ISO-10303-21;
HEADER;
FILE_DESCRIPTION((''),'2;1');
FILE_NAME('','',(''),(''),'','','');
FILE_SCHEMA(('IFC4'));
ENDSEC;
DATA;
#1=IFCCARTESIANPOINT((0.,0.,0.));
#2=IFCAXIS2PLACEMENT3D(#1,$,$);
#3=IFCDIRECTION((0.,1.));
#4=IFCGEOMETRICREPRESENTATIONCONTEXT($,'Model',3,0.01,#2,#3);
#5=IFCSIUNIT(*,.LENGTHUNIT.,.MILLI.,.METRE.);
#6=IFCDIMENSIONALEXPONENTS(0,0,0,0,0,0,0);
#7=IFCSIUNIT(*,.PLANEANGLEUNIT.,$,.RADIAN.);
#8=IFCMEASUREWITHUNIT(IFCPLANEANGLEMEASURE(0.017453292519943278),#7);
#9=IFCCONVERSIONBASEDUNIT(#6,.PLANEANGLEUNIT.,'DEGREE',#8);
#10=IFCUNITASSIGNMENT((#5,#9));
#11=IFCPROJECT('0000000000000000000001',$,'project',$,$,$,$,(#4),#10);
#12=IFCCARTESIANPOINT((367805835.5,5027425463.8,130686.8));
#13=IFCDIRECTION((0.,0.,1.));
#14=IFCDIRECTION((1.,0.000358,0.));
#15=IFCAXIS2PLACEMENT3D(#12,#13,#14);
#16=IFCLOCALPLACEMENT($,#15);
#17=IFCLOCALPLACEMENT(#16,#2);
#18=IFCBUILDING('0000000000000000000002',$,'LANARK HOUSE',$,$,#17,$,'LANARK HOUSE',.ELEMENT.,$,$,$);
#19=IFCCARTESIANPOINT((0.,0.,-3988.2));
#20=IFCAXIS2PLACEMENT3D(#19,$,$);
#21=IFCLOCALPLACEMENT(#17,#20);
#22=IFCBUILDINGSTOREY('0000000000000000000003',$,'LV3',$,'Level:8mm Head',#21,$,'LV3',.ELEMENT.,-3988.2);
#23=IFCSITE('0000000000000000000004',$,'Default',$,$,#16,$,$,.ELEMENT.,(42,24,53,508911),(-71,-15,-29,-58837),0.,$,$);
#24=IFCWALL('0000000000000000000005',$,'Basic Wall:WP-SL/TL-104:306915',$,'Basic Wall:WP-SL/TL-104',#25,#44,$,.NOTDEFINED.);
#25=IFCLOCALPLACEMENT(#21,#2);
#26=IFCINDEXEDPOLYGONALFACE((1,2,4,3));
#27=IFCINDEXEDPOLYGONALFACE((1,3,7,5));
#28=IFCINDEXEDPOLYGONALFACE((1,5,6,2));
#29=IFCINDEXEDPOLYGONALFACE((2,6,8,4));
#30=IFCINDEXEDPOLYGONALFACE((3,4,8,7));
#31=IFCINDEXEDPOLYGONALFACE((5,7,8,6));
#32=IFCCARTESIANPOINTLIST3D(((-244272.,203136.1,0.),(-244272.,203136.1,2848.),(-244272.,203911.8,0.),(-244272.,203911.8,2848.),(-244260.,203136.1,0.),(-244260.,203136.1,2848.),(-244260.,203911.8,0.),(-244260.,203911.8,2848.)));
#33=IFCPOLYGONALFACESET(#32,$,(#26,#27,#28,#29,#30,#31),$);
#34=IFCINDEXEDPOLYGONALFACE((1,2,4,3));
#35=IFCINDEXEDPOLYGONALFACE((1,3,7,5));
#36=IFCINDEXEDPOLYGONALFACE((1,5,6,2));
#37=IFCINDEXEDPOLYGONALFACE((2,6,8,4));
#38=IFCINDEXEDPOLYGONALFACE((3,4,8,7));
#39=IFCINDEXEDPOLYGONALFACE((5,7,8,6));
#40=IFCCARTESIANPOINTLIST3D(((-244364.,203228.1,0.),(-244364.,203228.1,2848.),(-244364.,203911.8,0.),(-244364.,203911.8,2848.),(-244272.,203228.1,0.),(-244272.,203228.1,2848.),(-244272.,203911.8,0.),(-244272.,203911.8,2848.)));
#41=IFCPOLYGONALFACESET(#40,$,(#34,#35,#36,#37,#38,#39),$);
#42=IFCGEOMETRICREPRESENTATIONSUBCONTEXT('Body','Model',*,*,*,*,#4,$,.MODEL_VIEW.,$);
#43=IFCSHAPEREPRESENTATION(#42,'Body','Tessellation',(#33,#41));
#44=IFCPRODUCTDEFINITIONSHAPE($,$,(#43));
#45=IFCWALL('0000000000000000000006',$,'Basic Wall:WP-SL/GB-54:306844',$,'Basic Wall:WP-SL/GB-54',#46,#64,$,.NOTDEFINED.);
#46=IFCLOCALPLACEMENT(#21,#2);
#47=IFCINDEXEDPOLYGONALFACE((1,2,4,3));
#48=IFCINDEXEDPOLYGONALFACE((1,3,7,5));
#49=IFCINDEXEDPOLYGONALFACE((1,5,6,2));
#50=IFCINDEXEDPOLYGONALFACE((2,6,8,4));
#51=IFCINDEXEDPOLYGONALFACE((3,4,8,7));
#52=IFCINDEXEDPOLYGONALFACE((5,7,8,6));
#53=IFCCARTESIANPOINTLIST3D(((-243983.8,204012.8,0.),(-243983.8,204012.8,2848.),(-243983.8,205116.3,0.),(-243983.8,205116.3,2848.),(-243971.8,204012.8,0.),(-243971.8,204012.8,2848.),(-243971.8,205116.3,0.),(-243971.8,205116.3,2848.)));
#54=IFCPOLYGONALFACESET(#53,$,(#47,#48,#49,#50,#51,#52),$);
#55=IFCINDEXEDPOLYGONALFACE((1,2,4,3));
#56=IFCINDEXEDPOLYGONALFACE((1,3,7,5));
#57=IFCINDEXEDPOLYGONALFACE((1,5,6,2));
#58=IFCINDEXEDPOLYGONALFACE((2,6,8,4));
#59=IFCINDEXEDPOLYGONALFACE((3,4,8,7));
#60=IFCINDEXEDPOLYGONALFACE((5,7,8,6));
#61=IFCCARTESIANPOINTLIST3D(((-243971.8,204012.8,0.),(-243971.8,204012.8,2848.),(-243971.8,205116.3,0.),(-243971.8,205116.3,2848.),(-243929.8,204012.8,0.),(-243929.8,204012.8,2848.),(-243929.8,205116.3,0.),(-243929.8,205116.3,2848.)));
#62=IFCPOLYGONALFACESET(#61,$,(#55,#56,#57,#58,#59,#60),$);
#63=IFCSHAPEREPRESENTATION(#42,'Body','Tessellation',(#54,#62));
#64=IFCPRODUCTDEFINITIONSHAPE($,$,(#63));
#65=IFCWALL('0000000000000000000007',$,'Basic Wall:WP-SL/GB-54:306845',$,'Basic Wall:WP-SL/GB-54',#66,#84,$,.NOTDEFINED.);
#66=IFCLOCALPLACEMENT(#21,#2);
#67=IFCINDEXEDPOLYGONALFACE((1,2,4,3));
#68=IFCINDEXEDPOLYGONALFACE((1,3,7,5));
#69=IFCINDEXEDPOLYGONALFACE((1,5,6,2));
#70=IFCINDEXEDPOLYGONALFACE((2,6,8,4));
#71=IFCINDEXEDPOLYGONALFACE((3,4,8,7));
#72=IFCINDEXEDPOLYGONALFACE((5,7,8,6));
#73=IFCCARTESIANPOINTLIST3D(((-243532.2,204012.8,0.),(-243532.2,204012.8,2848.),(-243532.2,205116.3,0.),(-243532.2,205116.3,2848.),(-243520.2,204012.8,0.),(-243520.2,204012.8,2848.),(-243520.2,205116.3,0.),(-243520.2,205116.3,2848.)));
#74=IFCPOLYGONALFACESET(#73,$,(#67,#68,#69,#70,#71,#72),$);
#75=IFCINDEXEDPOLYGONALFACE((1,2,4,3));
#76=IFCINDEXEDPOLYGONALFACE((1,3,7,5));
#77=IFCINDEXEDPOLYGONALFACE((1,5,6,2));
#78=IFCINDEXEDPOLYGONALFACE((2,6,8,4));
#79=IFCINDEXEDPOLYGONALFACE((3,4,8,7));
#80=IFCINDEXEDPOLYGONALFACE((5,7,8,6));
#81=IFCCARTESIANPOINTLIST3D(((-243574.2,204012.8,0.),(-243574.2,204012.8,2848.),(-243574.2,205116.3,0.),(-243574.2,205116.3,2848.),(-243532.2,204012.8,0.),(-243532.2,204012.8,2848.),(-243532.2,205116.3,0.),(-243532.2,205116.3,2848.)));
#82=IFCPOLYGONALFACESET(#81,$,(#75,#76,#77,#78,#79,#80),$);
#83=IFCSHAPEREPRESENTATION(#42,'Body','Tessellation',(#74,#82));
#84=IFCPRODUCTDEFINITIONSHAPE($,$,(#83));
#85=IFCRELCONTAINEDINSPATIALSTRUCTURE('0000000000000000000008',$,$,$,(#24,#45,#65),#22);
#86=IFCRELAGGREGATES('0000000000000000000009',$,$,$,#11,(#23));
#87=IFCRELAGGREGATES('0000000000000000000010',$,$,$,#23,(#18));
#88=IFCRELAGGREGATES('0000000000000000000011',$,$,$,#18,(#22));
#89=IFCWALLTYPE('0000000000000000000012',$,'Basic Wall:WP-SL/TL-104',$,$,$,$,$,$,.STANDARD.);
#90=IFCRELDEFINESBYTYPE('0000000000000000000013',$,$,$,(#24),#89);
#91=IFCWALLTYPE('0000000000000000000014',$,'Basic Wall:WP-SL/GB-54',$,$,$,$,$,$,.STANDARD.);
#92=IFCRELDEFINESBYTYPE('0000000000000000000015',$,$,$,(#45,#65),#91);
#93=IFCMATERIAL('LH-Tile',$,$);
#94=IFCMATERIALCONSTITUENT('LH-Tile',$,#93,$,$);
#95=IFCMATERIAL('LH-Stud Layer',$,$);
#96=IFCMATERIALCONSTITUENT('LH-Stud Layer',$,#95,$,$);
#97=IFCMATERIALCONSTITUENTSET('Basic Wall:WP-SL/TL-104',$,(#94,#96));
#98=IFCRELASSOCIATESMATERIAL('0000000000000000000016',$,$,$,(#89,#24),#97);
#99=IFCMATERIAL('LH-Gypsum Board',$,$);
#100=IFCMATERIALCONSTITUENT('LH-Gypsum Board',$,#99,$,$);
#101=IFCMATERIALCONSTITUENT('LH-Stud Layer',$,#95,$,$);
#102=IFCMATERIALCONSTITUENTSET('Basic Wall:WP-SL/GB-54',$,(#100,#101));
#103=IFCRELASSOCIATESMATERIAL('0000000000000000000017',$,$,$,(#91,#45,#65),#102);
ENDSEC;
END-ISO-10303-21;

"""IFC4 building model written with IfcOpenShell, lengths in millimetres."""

from ifc_helpers import new_model, entity, si_unit, converted_unit, direction, frame, origin, place, context, subcontext, project, spatial, indexed_curve, outline, extrude, material, constituent, constituent_set, type_object, element, save


model = new_model("IFC4")

# Units and contexts
model_context = context("Model", 3, precision=0.01, world=origin(), true_north=direction((0.0, 1.0)))
body_context = subcontext(model_context, "Body", "Model", "MODEL_VIEW")
ifc_project = project(units=[si_unit("LENGTHUNIT", "METRE", prefix="MILLI"), converted_unit("PLANEANGLEUNIT", "DEGREE", entity("IfcPlaneAngleMeasure", 0.017453292519943278), si_unit("PLANEANGLEUNIT", "RADIAN"), dimensions=[0, 0, 0, 0, 0, 0, 0])], contexts=[model_context])

# Site, building, storey
site_placement = place(None, frame((367805835.5, 5027425463.8, 130686.8), z_axis=(0.0, 0.0, 1.0), x_axis=(1.0, 0.000358, 0.0)))
site = spatial("IfcSite", under=ifc_project, at=site_placement, Name="Default", CompositionType="ELEMENT", RefLatitude=(42, 24, 53, 508911), RefLongitude=(-71, -15, -29, -58837), RefElevation=0.0)
building_placement = place(site_placement, origin())
building = spatial("IfcBuilding", under=site, at=building_placement, Name="LANARK HOUSE", LongName="LANARK HOUSE", CompositionType="ELEMENT")
storey_placement = place(building_placement, frame((0.0, 0.0, -3988.2)))
storey = spatial("IfcBuildingStorey", under=building, at=storey_placement, Name="LV3", ObjectType="Level:8mm Head", LongName="LV3", CompositionType="ELEMENT", Elevation=-3988.2)

# Walls
ifc_material_1 = material(Name="LH-Tile")
ifc_constituent_1 = constituent(ifc_material_1, Name="LH-Tile")
ifc_material_2 = material(Name="LH-Stud Layer")
ifc_constituent_2 = constituent(ifc_material_2, Name="LH-Stud Layer")
ifc_constituent_set_1 = constituent_set(constituents=[ifc_constituent_1, ifc_constituent_2], Name="Basic Wall:WP-SL/TL-104")
wall_type_1 = type_object("IfcWallType", Name="Basic Wall:WP-SL/TL-104", PredefinedType="STANDARD", material=ifc_constituent_set_1)
wall_1_placement = place(storey_placement, frame((-244312.0, 203911.8, 0.0), z_axis=(0.0, 0.0, 1.0), x_axis=(0.0, -1.0, 0.0)))
element("IfcWall", 1, at=wall_1_placement, inside=storey, type_object=wall_type_1, material=ifc_constituent_set_1, Name="Basic Wall:WP-SL/TL-104:306915", ObjectType="Basic Wall:WP-SL/TL-104", PredefinedType="NOTDEFINED", context=body_context, shape_type="SweptSolid", body=[
    extrude(outline(indexed_curve([(-6.0, -387.8), (6.0, -387.8), (6.0, 387.8), (-6.0, 387.8), (-6.0, -387.8)], self_intersect=False)), frame((387.8, 46.0, 0.0), z_axis=(0.0, 0.0, 1.0), x_axis=(0.0, -1.0, 0.0)), (0.0, 0.0, 1.0), 2848.0),
    extrude(outline(indexed_curve([(-46.0, -341.8), (46.0, -341.8), (46.0, 341.8), (-46.0, 341.8), (-46.0, -341.8)], self_intersect=False)), frame((341.8, -6.0, 0.0), z_axis=(0.0, 0.0, 1.0), x_axis=(0.0, 1.0, 0.0)), (0.0, 0.0, 1.0), 2848.0),
])
ifc_material_3 = material(Name="LH-Gypsum Board")
ifc_constituent_3 = constituent(ifc_material_3, Name="LH-Gypsum Board")
ifc_constituent_4 = constituent(ifc_material_2, Name="LH-Stud Layer")
ifc_constituent_set_2 = constituent_set(constituents=[ifc_constituent_3, ifc_constituent_4], Name="Basic Wall:WP-SL/GB-54")
wall_type_2 = type_object("IfcWallType", Name="Basic Wall:WP-SL/GB-54", PredefinedType="STANDARD", material=ifc_constituent_set_2)
wall_2_placement = place(storey_placement, frame((-243956.8, 204012.8, 0.0), z_axis=(0.0, 0.0, 1.0), x_axis=(0.0, 1.0, 0.0)))
element("IfcWall", 2, at=wall_2_placement, inside=storey, type_object=wall_type_2, material=ifc_constituent_set_2, Name="Basic Wall:WP-SL/GB-54:306844", ObjectType="Basic Wall:WP-SL/GB-54", PredefinedType="NOTDEFINED", context=body_context, shape_type="SweptSolid", body=[
    extrude(outline(indexed_curve([(-6.0, -551.8), (6.0, -551.8), (6.0, 551.8), (-6.0, 551.8), (-6.0, -551.8)], self_intersect=False)), frame((551.8, 21.0, 0.0), z_axis=(0.0, 0.0, 1.0), x_axis=(0.0, -1.0, 0.0)), (0.0, 0.0, 1.0), 2848.0),
    extrude(outline(indexed_curve([(-21.0, -551.8), (21.0, -551.8), (21.0, 551.8), (-21.0, 551.8), (-21.0, -551.8)], self_intersect=False)), frame((551.8, -6.0, 0.0), z_axis=(0.0, 0.0, 1.0), x_axis=(0.0, 1.0, 0.0)), (0.0, 0.0, 1.0), 2848.0),
])
wall_3_placement = place(storey_placement, frame((-243547.2, 205116.3, 0.0), z_axis=(0.0, 0.0, 1.0), x_axis=(0.0, -1.0, 0.0)))
element("IfcWall", 3, at=wall_3_placement, inside=storey, type_object=wall_type_2, material=ifc_constituent_set_2, Name="Basic Wall:WP-SL/GB-54:306845", ObjectType="Basic Wall:WP-SL/GB-54", PredefinedType="NOTDEFINED", context=body_context, shape_type="SweptSolid", body=[
    extrude(outline(indexed_curve([(-6.0, -551.8), (6.0, -551.8), (6.0, 551.8), (-6.0, 551.8), (-6.0, -551.8)], self_intersect=False)), frame((551.8, 21.0, 0.0), z_axis=(0.0, 0.0, 1.0), x_axis=(0.0, -1.0, 0.0)), (0.0, 0.0, 1.0), 2848.0),
    extrude(outline(indexed_curve([(-21.0, -551.8), (21.0, -551.8), (21.0, 551.8), (-21.0, 551.8), (-21.0, -551.8)], self_intersect=False)), frame((551.8, -6.0, 0.0), z_axis=(0.0, 0.0, 1.0), x_axis=(0.0, 1.0, 0.0)), (0.0, 0.0, 1.0), 2848.0),
])

save(model, "model.ifc")
